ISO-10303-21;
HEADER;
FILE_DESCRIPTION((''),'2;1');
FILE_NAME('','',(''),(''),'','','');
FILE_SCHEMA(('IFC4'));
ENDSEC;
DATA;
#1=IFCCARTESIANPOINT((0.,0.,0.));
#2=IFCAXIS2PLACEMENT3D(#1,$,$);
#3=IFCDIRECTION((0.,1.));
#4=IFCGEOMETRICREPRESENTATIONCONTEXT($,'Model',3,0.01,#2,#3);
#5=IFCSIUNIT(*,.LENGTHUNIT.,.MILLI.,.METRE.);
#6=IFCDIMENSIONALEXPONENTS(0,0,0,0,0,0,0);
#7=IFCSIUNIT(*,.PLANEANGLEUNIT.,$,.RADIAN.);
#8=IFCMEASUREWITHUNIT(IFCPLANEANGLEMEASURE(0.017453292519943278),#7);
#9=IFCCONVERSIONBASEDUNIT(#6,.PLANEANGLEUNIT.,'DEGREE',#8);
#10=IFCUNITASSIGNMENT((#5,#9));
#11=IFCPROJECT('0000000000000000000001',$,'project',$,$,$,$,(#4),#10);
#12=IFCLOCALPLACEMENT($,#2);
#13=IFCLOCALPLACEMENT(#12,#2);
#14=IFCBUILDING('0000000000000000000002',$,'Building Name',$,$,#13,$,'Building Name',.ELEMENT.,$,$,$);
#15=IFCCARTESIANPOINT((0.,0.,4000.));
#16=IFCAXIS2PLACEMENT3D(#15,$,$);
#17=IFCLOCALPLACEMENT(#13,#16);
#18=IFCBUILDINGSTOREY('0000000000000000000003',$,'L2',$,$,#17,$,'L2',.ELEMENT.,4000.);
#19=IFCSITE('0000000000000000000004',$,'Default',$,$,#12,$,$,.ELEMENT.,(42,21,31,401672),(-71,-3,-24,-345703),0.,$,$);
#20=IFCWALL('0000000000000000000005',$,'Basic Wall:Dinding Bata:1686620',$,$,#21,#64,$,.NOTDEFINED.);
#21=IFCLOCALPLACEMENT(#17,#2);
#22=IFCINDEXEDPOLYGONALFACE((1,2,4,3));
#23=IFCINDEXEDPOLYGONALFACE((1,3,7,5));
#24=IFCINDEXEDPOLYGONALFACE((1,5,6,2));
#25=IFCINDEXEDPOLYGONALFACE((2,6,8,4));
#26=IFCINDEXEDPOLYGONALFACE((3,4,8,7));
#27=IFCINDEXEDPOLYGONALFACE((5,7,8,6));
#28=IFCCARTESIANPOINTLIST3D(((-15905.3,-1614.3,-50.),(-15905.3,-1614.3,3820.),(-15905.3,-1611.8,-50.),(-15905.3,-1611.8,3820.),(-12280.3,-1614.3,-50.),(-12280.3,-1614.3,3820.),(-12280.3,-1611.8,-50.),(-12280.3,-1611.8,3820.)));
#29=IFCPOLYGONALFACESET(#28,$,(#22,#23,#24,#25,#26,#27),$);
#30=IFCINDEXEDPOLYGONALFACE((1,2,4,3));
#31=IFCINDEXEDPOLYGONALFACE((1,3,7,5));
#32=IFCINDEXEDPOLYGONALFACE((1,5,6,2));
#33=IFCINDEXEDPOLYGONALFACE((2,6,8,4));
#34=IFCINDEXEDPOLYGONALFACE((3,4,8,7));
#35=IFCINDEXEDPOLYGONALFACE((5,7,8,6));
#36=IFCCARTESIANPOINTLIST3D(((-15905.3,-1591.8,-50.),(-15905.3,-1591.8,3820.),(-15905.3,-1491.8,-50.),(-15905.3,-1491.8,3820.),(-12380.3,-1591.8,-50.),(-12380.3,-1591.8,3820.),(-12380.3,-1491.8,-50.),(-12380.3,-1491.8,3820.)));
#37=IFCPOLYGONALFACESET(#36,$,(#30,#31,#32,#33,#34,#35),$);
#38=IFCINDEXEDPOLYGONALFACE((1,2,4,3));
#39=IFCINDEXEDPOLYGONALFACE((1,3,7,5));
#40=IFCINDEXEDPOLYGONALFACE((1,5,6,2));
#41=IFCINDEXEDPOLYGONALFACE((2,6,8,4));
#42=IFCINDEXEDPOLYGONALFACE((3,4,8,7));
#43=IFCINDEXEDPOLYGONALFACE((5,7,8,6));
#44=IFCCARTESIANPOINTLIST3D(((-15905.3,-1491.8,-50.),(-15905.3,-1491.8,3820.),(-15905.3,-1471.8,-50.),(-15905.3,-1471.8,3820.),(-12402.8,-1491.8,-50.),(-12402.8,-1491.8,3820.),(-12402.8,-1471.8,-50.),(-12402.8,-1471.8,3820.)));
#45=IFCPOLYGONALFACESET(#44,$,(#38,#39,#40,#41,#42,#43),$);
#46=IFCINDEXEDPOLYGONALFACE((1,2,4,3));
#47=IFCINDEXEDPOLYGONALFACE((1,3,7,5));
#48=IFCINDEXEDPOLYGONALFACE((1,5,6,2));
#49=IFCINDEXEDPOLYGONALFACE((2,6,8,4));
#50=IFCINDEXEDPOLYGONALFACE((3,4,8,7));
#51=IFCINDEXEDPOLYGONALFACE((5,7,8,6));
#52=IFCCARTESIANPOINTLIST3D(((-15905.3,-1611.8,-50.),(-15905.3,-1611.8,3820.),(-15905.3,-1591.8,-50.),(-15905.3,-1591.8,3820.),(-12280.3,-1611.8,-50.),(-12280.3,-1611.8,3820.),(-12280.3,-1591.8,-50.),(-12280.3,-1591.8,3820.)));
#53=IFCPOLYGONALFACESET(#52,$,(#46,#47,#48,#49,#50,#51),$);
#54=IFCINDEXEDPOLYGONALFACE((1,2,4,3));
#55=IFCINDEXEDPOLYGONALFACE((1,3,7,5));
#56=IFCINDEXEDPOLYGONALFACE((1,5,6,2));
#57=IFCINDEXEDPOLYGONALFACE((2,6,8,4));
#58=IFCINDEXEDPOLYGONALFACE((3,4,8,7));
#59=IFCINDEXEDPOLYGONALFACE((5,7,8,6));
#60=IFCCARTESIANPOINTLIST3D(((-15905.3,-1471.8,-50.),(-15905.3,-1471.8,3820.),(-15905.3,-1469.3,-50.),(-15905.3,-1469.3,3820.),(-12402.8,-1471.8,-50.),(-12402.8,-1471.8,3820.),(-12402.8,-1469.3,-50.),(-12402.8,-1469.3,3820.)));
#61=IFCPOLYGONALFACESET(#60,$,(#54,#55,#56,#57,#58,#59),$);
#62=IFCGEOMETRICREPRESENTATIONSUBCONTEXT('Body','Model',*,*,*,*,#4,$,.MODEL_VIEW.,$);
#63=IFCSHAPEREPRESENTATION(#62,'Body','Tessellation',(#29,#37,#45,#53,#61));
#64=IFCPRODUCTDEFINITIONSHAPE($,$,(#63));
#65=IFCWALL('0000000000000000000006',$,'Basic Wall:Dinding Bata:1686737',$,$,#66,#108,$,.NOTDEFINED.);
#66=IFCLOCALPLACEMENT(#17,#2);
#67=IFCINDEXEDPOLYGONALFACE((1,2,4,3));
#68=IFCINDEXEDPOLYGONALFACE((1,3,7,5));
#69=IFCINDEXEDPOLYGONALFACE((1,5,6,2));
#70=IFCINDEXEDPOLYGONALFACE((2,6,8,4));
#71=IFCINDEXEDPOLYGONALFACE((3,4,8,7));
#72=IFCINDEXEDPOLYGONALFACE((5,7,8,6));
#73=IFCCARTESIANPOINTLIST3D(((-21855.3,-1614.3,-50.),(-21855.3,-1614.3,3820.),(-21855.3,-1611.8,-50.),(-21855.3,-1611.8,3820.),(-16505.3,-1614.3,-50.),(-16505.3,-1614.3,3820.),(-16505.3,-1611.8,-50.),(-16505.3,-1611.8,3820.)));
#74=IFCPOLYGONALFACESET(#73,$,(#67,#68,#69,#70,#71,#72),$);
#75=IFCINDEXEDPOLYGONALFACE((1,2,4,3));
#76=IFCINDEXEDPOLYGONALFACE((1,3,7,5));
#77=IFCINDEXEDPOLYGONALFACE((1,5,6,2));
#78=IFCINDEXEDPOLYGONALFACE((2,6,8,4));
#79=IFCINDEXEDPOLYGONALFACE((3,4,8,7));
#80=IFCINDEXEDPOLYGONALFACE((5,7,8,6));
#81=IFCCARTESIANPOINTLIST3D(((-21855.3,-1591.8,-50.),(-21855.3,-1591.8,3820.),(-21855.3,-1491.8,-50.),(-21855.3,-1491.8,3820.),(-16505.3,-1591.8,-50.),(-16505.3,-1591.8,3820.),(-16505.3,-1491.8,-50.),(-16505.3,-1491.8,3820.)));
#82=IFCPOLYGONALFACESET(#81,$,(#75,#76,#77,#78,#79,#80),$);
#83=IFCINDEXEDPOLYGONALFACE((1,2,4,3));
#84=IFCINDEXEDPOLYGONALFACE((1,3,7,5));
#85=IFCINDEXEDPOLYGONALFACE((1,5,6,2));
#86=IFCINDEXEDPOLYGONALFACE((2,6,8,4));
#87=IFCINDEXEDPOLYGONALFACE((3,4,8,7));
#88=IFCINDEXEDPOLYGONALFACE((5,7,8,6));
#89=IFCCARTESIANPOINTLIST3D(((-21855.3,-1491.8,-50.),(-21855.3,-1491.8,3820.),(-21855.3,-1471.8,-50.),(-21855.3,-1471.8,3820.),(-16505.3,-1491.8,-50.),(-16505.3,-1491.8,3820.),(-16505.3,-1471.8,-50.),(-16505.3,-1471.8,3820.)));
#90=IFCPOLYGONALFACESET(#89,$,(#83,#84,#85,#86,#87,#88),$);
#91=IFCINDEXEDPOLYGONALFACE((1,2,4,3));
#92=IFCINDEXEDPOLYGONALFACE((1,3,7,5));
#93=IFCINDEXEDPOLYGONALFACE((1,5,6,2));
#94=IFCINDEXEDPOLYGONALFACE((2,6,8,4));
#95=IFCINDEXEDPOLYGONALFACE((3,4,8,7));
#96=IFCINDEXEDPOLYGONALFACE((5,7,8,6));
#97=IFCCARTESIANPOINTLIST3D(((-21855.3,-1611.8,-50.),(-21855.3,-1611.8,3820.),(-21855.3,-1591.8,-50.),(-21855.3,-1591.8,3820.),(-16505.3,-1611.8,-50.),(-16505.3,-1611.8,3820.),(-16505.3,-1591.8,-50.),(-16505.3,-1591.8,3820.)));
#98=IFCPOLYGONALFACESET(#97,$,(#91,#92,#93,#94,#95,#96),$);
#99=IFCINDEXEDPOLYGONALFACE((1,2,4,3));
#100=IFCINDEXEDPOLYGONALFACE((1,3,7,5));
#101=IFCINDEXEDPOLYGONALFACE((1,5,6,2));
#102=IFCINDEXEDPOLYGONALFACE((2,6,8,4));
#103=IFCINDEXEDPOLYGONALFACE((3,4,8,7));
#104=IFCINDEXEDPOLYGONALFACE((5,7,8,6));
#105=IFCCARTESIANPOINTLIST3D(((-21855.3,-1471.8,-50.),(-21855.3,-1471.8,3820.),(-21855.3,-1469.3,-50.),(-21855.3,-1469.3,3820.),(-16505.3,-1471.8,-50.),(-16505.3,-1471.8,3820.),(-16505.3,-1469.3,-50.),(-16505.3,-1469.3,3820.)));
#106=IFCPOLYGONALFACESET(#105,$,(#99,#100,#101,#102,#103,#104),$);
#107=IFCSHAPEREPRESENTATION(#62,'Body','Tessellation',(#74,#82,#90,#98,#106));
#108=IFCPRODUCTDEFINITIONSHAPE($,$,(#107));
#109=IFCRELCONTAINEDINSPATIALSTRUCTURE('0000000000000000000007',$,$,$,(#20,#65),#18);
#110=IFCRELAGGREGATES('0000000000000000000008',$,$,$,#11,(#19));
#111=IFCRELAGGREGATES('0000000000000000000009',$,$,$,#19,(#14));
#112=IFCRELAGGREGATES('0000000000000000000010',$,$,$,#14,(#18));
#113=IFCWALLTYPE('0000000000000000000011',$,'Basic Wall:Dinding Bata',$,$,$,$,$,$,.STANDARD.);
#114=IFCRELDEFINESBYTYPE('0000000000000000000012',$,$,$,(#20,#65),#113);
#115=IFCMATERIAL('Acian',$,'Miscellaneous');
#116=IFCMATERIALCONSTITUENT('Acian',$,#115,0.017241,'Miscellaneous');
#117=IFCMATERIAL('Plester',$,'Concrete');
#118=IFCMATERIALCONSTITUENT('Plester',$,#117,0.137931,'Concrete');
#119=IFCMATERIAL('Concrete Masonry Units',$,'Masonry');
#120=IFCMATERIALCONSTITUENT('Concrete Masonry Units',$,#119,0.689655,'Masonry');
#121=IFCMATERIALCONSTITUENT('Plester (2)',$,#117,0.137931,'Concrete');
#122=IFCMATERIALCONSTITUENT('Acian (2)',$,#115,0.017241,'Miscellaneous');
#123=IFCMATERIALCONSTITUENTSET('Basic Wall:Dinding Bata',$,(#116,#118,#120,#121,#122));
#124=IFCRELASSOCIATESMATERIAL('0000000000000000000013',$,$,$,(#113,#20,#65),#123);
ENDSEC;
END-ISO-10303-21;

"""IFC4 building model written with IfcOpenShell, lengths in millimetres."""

from ifc_helpers import new_model, entity, si_unit, converted_unit, direction, frame, origin, place, context, subcontext, project, spatial, indexed_curve, outline, extrude, material, constituent, constituent_set, type_object, element, save


model = new_model("IFC4")

# Units and contexts
model_context = context("Model", 3, precision=0.01, world=origin(), true_north=direction((0.0, 1.0)))
body_context = subcontext(model_context, "Body", "Model", "MODEL_VIEW")
ifc_project = project(units=[si_unit("LENGTHUNIT", "METRE", prefix="MILLI"), converted_unit("PLANEANGLEUNIT", "DEGREE", entity("IfcPlaneAngleMeasure", 0.017453292519943278), si_unit("PLANEANGLEUNIT", "RADIAN"), dimensions=[0, 0, 0, 0, 0, 0, 0])], contexts=[model_context])

# Site, building, storey
site_placement = place(None, origin())
site = spatial("IfcSite", under=ifc_project, at=site_placement, Name="Default", CompositionType="ELEMENT", RefLatitude=(42, 21, 31, 401672), RefLongitude=(-71, -3, -24, -345703), RefElevation=0.0)
building_placement = place(site_placement, origin())
building = spatial("IfcBuilding", under=site, at=building_placement, Name="Building Name", LongName="Building Name", CompositionType="ELEMENT")
storey_placement = place(building_placement, frame((0.0, 0.0, 4000.0)))
storey = spatial("IfcBuildingStorey", under=building, at=storey_placement, Name="L2", LongName="L2", CompositionType="ELEMENT", Elevation=4000.0)

# Walls
ifc_material_1 = material(Name="Acian", Category="Miscellaneous")
ifc_constituent_1 = constituent(ifc_material_1, Name="Acian", Category="Miscellaneous", fraction=0.017241)
ifc_material_2 = material(Name="Plester", Category="Concrete")
ifc_constituent_2 = constituent(ifc_material_2, Name="Plester", Category="Concrete", fraction=0.137931)
ifc_material_3 = material(Name="Concrete Masonry Units", Category="Masonry")
ifc_constituent_3 = constituent(ifc_material_3, Name="Concrete Masonry Units", Category="Masonry", fraction=0.689655)
ifc_constituent_4 = constituent(ifc_material_2, Name="Plester (2)", Category="Concrete", fraction=0.137931)
ifc_constituent_5 = constituent(ifc_material_1, Name="Acian (2)", Category="Miscellaneous", fraction=0.017241)
ifc_constituent_set = constituent_set(constituents=[ifc_constituent_1, ifc_constituent_2, ifc_constituent_3, ifc_constituent_4, ifc_constituent_5], Name="Basic Wall:Dinding Bata")
wall_type = type_object("IfcWallType", Name="Basic Wall:Dinding Bata", PredefinedType="STANDARD", material=ifc_constituent_set)
wall_1_placement = place(storey_placement, frame((-12402.8, -1541.8, -50.0), z_axis=(0.0, 0.0, 1.0), x_axis=(-1.0, 0.0, 0.0)))
element("IfcWall", 1, at=wall_1_placement, inside=storey, type_object=wall_type, material=ifc_constituent_set, Name="Basic Wall:Dinding Bata:1686620", PredefinedType="NOTDEFINED", context=body_context, shape_type="SweptSolid", body=[
    extrude(outline(indexed_curve([(-1.3, -1812.5), (1.2, -1812.5), (1.3, 1812.5), (-1.2, 1812.5), (-1.3, -1812.5)], self_intersect=False)), frame((1690.0, 71.3, 0.0), z_axis=(0.0, 0.0, 1.0), x_axis=(0.0, -1.0, 0.0)), (0.0, 0.0, 1.0), 3870.0),
    extrude(outline(indexed_curve([(-1762.5, -50.0), (1762.5, -50.0), (1762.5, 50.0), (-1762.5, 50.0), (-1762.5, -50.0)], self_intersect=False)), frame((1740.0, 0.0, 0.0)), (0.0, 0.0, 1.0), 3870.0),
    extrude(outline(indexed_curve([(-1751.3, -10.0), (1751.3, -10.0), (1751.3, 10.0), (-1751.3, 10.0), (-1751.3, -10.0)], self_intersect=False)), frame((1751.3, -60.0, 0.0)), (0.0, 0.0, 1.0), 3870.0),
    extrude(outline(indexed_curve([(-1812.5, -10.0), (1812.5, -10.0), (1812.5, 10.0), (-1812.5, 10.0), (-1812.5, -10.0)], self_intersect=False)), frame((1690.0, 60.0, 0.0)), (0.0, 0.0, 1.0), 3870.0),
    extrude(outline(indexed_curve([(-1.3, -1751.3), (1.2, -1751.3), (1.3, 1751.3), (-1.2, 1751.3), (-1.3, -1751.3)], self_intersect=False)), frame((1751.3, -71.3, 0.0), z_axis=(0.0, 0.0, 1.0), x_axis=(0.0, 1.0, 0.0)), (0.0, 0.0, 1.0), 3870.0),
])
wall_2_placement = place(storey_placement, frame((-16505.3, -1541.8, -50.0), z_axis=(0.0, 0.0, 1.0), x_axis=(-1.0, 0.0, 0.0)))
element("IfcWall", 2, at=wall_2_placement, inside=storey, type_object=wall_type, material=ifc_constituent_set, Name="Basic Wall:Dinding Bata:1686737", PredefinedType="NOTDEFINED", context=body_context, shape_type="SweptSolid", body=[
    extrude(outline(indexed_curve([(-1.3, -2675.0), (1.2, -2675.0), (1.3, 2675.0), (-1.2, 2675.0), (-1.3, -2675.0)], self_intersect=False)), frame((2675.0, 71.3, 0.0), z_axis=(0.0, 0.0, 1.0), x_axis=(0.0, -1.0, 0.0)), (0.0, 0.0, 1.0), 3870.0),
    extrude(outline(indexed_curve([(-2675.0, -50.0), (2675.0, -50.0), (2675.0, 50.0), (-2675.0, 50.0), (-2675.0, -50.0)], self_intersect=False)), frame((2675.0, 0.0, 0.0)), (0.0, 0.0, 1.0), 3870.0),
    extrude(outline(indexed_curve([(-2675.0, -10.0), (2675.0, -10.0), (2675.0, 10.0), (-2675.0, 10.0), (-2675.0, -10.0)], self_intersect=False)), frame((2675.0, -60.0, 0.0)), (0.0, 0.0, 1.0), 3870.0),
    extrude(outline(indexed_curve([(-2675.0, -10.0), (2675.0, -10.0), (2675.0, 10.0), (-2675.0, 10.0), (-2675.0, -10.0)], self_intersect=False)), frame((2675.0, 60.0, 0.0)), (0.0, 0.0, 1.0), 3870.0),
    extrude(outline(indexed_curve([(-1.3, -2675.0), (1.2, -2675.0), (1.3, 2675.0), (-1.2, 2675.0), (-1.3, -2675.0)], self_intersect=False)), frame((2675.0, -71.3, 0.0), z_axis=(0.0, 0.0, 1.0), x_axis=(0.0, 1.0, 0.0)), (0.0, 0.0, 1.0), 3870.0),
])

save(model, "model.ifc")
